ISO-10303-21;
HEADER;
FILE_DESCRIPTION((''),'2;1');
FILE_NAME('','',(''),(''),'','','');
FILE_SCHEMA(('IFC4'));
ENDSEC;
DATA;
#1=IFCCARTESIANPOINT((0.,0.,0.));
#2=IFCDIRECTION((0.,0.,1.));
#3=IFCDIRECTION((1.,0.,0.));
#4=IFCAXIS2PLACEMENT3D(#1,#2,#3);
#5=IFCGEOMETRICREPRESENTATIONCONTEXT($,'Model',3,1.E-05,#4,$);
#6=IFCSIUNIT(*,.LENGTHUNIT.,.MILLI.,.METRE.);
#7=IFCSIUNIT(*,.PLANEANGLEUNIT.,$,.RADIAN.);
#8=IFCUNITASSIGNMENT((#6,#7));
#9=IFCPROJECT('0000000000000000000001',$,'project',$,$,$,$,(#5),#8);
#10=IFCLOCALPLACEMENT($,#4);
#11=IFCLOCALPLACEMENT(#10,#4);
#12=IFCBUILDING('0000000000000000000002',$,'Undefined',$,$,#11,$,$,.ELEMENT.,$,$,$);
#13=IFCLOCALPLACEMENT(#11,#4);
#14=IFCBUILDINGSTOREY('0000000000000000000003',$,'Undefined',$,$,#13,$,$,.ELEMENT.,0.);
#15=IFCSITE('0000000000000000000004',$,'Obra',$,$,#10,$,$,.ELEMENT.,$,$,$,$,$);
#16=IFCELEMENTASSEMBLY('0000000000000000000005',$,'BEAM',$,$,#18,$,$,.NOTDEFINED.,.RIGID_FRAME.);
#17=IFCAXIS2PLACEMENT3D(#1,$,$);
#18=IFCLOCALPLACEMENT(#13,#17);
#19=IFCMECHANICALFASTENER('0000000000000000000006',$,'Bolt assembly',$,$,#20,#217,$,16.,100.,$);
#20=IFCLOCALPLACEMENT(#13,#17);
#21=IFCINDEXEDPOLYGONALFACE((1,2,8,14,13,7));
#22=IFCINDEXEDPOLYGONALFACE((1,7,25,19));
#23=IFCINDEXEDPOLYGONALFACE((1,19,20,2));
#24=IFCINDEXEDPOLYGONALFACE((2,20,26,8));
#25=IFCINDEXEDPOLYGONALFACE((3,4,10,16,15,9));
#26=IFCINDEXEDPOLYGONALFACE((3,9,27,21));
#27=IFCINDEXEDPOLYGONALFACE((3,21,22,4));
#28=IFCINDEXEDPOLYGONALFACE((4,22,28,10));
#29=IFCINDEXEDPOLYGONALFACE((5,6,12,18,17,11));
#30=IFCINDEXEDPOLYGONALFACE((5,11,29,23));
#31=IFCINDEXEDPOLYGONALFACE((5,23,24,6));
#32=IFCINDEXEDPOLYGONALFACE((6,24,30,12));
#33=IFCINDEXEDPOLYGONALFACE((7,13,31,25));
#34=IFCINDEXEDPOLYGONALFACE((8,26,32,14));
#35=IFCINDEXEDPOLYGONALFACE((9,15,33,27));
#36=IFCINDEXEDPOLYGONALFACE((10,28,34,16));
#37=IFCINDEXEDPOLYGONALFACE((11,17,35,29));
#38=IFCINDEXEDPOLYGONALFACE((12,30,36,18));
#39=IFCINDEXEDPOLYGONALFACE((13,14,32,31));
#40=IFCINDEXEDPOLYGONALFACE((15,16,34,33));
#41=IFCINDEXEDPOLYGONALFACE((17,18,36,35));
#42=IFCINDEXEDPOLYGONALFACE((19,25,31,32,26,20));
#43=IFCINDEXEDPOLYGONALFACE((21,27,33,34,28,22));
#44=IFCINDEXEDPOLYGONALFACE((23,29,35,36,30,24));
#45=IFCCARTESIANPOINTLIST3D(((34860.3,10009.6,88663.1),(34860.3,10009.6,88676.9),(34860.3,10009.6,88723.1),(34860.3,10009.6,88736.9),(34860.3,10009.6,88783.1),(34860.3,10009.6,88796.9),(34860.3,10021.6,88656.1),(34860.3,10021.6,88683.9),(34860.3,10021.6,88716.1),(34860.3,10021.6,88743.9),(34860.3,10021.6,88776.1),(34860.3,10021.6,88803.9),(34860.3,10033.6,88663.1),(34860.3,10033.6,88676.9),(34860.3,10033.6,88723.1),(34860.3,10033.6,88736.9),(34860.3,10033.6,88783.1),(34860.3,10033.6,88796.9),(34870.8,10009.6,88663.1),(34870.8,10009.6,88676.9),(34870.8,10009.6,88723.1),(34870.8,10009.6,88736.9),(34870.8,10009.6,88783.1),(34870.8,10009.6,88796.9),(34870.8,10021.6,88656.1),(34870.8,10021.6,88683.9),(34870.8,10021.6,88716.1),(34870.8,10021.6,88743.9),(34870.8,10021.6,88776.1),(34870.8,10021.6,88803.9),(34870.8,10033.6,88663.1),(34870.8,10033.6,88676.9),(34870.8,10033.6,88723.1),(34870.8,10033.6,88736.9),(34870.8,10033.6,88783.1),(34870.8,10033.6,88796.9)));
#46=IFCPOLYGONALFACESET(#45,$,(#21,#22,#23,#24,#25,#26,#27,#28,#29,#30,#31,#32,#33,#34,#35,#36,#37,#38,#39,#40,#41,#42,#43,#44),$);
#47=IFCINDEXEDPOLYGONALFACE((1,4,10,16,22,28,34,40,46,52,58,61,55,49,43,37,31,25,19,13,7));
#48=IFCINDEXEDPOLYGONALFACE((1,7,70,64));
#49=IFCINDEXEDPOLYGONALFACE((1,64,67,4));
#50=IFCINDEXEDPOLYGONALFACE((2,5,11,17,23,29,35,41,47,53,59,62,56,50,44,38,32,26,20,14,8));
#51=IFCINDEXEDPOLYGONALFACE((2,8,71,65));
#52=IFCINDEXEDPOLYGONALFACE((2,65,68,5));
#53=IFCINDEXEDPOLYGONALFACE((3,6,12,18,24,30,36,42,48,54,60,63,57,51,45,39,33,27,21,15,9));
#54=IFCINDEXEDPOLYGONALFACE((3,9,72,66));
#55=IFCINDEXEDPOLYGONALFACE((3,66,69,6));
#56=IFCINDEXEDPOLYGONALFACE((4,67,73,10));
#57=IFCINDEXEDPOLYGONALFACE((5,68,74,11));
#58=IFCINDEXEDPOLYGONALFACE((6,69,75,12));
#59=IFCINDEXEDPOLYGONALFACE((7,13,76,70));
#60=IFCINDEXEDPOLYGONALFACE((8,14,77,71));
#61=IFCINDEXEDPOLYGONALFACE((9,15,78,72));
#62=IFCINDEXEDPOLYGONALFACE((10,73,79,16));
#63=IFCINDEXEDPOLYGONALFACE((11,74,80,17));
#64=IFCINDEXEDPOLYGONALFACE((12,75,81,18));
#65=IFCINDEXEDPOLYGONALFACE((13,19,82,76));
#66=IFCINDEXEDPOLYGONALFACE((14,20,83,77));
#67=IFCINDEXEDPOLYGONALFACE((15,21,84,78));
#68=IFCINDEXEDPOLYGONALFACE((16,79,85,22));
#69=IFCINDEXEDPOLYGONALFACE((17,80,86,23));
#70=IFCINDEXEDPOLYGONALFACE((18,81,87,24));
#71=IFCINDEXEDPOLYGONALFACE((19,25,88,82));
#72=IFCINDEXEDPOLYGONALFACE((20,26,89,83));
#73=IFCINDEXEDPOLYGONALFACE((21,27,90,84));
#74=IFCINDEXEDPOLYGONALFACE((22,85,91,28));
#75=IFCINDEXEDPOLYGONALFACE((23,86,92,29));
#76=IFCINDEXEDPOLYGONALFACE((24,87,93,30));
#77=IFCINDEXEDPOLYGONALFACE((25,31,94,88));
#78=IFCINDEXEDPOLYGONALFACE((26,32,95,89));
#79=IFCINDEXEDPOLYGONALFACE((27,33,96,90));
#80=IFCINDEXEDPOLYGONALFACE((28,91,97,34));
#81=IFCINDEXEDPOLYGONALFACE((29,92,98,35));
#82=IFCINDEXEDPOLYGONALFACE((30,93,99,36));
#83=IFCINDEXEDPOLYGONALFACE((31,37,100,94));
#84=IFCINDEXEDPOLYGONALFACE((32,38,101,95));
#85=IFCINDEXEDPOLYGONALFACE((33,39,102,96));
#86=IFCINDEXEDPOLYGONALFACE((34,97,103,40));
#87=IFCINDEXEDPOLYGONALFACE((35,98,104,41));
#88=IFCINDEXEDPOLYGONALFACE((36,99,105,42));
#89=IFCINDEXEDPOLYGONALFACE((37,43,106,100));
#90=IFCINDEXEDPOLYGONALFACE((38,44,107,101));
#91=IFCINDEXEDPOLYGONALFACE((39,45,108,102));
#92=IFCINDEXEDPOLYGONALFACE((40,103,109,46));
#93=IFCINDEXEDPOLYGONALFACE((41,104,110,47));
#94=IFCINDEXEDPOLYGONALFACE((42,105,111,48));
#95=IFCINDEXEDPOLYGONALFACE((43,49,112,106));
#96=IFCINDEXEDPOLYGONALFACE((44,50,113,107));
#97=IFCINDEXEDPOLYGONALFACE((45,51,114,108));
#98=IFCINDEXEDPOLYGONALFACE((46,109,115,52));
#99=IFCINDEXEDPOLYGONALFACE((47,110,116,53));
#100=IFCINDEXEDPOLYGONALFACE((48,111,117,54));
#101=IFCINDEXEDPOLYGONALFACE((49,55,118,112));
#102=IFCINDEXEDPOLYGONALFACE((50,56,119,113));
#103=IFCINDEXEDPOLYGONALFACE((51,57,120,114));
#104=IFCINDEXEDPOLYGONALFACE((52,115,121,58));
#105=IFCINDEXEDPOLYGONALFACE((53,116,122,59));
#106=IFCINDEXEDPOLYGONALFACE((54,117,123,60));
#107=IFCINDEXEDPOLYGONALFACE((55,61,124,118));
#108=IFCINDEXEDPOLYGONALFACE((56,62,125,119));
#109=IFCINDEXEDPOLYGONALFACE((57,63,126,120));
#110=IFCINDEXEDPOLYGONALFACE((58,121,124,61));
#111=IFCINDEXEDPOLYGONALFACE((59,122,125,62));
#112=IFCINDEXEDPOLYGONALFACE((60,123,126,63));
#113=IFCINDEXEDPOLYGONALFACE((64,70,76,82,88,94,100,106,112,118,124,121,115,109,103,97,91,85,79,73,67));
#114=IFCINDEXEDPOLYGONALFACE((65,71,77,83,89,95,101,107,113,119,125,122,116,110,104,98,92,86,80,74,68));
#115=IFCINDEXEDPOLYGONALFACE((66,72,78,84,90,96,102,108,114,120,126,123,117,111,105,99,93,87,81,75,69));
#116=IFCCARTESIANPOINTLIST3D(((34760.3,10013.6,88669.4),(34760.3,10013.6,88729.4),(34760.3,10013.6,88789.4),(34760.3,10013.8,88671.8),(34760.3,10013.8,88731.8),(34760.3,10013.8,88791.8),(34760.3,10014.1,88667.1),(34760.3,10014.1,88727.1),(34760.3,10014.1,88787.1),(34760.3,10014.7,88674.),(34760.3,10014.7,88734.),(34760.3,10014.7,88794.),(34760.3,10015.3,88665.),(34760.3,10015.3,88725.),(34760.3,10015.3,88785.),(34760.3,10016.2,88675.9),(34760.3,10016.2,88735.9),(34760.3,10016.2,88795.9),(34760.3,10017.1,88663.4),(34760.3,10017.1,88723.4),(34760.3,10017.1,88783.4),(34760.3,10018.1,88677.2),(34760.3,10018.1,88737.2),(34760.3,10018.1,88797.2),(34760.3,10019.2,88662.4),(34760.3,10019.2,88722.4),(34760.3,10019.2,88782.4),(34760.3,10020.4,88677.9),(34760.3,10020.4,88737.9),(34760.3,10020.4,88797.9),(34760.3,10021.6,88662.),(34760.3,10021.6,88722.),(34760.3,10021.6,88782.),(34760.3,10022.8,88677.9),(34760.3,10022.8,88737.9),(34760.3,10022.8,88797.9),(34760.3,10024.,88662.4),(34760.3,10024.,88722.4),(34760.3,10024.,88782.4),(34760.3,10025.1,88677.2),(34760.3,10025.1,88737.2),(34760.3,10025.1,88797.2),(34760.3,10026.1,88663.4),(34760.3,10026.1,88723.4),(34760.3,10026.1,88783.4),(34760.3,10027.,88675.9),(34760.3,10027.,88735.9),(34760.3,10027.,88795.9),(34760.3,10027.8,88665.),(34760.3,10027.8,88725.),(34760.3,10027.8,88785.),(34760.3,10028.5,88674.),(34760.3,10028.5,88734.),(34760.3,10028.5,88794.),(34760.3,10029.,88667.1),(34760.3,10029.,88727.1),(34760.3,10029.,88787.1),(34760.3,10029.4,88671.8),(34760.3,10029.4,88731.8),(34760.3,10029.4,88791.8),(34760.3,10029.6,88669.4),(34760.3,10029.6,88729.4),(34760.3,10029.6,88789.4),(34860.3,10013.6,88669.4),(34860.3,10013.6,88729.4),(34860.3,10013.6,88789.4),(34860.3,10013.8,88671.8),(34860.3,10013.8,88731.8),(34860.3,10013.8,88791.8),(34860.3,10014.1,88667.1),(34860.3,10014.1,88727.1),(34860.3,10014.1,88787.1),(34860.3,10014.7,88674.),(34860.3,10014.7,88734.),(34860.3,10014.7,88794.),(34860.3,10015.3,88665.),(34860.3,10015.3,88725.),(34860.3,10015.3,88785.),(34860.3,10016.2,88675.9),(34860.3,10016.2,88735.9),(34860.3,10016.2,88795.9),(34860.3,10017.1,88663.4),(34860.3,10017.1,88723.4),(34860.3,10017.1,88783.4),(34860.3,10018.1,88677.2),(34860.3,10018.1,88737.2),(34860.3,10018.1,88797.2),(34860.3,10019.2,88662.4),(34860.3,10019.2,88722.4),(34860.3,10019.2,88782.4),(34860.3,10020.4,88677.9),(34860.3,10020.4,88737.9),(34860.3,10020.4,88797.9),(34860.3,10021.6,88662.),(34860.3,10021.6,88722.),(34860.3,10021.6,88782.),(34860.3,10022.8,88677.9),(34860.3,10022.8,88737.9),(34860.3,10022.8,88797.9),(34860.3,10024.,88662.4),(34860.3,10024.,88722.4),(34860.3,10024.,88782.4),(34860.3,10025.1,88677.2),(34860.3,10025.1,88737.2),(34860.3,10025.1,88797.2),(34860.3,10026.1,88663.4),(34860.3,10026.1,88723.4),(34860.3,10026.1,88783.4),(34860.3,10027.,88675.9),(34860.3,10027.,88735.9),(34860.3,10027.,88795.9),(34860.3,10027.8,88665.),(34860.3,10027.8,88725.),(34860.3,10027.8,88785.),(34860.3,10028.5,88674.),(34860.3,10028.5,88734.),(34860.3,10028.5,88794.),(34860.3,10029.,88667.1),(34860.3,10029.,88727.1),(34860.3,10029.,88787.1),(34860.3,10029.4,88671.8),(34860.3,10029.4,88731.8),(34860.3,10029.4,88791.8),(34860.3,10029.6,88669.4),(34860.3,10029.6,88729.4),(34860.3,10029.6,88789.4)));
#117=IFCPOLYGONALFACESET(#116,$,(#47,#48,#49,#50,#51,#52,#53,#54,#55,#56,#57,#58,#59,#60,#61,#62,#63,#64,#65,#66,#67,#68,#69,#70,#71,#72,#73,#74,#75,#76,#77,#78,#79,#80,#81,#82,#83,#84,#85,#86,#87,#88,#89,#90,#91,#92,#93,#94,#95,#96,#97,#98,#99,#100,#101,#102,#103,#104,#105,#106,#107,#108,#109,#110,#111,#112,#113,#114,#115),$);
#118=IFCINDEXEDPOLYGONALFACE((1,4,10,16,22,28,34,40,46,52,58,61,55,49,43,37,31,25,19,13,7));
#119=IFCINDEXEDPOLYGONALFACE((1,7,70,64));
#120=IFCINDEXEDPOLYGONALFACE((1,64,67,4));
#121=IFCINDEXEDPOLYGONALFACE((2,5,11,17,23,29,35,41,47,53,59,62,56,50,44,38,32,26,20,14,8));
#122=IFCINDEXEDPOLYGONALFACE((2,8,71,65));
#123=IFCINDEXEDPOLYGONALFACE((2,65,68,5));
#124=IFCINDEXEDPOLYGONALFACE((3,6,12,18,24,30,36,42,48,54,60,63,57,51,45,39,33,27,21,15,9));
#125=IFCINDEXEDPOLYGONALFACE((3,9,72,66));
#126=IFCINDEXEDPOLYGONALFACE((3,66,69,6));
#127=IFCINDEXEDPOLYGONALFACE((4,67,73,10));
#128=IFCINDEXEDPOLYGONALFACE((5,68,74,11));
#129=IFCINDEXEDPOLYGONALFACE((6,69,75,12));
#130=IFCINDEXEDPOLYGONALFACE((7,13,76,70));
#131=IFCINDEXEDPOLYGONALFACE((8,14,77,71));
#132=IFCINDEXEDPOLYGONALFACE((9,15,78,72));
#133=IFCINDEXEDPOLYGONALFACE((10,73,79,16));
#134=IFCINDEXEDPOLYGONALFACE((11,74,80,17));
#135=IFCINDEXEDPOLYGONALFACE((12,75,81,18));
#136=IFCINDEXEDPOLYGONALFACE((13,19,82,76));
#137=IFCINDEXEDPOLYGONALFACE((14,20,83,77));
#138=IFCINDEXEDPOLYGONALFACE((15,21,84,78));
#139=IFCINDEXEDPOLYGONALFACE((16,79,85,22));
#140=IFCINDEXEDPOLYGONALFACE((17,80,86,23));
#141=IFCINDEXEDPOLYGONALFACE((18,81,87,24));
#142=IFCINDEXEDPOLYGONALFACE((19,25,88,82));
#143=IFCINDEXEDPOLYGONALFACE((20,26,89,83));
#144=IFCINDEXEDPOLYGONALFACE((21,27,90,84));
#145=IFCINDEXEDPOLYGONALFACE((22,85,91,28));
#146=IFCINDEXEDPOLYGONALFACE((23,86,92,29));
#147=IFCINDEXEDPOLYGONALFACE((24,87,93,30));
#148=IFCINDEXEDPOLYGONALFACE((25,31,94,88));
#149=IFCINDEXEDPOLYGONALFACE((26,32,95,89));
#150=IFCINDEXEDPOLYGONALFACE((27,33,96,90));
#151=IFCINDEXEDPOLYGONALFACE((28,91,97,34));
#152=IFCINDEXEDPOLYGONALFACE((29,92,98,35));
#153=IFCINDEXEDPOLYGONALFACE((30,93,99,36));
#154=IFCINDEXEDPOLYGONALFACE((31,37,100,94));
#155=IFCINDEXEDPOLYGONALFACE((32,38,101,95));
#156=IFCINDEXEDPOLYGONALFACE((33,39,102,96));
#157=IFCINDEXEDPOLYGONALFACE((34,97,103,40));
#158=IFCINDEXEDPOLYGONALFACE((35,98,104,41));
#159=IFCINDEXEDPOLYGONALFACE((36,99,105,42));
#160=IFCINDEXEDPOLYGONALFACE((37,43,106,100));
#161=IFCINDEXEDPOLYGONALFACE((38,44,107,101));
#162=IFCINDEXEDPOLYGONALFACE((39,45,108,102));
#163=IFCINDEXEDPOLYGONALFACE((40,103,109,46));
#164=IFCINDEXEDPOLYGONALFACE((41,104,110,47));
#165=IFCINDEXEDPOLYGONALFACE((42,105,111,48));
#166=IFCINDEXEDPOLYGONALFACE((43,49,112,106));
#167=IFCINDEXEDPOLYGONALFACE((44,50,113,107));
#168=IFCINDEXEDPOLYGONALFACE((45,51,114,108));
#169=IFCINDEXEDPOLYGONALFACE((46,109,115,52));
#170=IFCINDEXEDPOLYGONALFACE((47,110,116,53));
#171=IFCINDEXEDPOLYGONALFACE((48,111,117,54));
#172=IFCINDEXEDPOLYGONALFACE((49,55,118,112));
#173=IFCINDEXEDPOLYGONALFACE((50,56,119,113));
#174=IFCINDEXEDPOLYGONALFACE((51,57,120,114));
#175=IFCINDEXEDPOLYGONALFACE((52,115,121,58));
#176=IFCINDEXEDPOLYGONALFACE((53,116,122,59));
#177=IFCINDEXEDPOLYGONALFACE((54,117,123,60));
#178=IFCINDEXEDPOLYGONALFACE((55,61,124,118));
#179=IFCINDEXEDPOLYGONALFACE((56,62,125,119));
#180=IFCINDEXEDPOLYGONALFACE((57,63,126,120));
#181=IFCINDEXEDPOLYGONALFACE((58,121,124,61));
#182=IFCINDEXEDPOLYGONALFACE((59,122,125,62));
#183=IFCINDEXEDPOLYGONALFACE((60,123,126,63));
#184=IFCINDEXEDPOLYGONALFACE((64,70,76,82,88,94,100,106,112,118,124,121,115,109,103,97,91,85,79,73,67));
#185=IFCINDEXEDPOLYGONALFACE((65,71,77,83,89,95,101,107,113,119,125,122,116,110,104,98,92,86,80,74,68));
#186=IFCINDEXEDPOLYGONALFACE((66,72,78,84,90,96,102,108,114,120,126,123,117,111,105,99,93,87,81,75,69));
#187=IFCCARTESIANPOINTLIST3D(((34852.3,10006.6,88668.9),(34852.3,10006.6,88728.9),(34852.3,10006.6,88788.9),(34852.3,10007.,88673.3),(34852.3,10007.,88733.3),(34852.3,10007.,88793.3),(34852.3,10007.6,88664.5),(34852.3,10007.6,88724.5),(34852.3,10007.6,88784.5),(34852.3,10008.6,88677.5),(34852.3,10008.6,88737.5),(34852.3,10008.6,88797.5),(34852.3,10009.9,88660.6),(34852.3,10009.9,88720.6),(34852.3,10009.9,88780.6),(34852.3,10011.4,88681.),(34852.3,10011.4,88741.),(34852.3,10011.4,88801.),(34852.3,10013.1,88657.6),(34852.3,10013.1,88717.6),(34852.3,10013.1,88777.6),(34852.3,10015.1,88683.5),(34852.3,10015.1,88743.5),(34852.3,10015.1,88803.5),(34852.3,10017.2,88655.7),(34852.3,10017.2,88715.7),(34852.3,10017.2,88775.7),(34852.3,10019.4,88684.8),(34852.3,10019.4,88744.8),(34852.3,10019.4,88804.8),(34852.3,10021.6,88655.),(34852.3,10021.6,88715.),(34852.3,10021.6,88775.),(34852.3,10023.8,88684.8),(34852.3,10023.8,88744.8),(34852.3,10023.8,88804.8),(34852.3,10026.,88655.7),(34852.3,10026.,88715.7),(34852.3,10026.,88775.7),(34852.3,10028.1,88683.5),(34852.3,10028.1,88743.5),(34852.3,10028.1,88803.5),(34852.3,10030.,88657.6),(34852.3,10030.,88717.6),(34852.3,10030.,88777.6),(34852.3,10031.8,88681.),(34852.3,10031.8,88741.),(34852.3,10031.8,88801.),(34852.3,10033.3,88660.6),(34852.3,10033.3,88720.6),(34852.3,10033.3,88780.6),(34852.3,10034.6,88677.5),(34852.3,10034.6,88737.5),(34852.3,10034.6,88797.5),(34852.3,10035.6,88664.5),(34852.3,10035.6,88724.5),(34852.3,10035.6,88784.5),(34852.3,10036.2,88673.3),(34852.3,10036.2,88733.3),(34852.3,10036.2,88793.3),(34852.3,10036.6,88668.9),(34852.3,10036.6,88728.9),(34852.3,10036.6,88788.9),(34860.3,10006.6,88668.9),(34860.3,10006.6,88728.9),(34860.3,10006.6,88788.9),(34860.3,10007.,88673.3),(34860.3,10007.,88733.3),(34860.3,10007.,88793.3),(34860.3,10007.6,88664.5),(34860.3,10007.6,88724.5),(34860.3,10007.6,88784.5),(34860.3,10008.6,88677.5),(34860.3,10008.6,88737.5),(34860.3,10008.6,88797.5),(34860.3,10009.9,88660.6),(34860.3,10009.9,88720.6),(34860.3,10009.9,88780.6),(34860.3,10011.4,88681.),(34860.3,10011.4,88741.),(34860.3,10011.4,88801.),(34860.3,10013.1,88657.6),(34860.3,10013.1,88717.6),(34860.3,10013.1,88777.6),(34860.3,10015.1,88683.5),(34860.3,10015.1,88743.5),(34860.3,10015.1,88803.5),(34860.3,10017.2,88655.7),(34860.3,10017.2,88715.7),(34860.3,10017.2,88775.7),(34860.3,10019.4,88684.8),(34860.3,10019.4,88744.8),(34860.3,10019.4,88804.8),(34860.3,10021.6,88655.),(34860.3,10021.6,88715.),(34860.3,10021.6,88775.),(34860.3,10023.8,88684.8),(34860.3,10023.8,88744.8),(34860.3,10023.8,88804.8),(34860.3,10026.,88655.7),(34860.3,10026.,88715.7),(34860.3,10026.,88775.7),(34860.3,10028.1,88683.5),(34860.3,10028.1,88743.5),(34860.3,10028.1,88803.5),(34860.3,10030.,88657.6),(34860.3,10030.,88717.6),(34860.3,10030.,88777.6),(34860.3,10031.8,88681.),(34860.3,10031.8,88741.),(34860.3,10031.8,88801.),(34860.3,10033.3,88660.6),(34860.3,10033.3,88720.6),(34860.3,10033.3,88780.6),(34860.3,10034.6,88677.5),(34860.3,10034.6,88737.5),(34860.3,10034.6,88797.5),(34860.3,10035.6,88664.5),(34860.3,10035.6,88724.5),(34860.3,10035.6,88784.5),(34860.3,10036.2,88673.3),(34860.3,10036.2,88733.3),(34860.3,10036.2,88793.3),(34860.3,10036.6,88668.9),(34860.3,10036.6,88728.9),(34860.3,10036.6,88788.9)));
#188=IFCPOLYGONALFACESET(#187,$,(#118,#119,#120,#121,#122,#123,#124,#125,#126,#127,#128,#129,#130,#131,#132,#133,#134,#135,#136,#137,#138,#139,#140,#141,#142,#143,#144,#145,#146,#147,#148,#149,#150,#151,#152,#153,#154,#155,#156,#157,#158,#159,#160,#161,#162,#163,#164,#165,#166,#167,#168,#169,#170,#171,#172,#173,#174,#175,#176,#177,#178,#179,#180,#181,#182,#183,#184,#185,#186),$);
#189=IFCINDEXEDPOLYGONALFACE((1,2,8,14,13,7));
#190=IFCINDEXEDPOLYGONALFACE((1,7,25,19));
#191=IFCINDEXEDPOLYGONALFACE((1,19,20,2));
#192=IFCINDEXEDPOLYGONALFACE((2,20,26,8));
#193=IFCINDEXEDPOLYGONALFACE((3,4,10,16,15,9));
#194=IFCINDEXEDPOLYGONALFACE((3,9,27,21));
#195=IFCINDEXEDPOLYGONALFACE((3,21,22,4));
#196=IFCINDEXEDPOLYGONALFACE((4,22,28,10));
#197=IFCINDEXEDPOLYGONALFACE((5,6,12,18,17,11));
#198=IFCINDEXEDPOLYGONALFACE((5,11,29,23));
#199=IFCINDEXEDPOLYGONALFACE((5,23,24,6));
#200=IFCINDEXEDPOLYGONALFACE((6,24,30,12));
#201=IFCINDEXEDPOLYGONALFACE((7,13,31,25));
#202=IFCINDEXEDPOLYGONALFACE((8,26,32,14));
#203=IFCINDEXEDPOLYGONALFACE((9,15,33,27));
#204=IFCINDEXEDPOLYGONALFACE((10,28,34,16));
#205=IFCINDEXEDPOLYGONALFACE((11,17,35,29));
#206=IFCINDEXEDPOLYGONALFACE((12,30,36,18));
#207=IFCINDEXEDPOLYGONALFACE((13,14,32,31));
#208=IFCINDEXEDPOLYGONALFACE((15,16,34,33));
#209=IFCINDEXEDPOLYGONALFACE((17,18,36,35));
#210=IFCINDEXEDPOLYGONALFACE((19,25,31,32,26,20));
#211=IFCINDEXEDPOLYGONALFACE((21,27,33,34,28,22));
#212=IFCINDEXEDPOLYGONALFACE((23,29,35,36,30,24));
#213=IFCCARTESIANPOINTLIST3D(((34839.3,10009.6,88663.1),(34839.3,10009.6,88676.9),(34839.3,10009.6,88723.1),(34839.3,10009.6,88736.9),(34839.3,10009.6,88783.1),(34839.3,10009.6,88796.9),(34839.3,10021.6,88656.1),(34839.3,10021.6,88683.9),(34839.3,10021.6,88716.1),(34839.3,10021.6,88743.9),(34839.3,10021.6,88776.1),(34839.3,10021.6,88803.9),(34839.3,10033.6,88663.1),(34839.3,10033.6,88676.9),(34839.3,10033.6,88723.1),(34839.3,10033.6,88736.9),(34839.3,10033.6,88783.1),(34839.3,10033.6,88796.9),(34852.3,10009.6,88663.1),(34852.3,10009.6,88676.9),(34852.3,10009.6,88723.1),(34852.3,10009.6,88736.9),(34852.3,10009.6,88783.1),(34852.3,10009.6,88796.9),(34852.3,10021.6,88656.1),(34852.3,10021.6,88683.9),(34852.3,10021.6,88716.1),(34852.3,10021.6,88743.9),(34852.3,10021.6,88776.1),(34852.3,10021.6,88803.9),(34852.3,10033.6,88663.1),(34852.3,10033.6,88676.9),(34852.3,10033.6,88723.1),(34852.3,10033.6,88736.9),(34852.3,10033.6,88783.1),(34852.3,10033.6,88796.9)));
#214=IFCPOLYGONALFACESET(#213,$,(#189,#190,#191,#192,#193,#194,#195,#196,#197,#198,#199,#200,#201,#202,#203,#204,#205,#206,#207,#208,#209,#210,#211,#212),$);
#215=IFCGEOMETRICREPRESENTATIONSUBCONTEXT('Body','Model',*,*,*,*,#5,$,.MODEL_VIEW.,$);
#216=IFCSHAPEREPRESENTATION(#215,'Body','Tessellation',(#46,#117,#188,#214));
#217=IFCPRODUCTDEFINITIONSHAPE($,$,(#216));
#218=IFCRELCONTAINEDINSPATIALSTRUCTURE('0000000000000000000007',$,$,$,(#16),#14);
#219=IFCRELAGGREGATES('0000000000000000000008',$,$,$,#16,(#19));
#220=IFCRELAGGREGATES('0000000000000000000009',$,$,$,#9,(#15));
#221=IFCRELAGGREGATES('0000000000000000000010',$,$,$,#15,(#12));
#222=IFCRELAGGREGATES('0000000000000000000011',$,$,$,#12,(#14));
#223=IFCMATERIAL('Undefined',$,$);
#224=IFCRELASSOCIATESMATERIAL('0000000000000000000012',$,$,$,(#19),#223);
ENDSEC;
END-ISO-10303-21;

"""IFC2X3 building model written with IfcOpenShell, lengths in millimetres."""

from ifc_helpers import new_model, si_unit, frame, origin_with_axes, origin_2d_with_axis, place, context, subcontext, project, spatial, polyline, circle, outline, extrude, source, transform, mapped, material, element, aggregate, save


model = new_model("IFC2X3")

# Units and contexts
model_context = context("Model", 3, precision=1e-05, world=origin_with_axes())
body_context = subcontext(model_context, "Body", "Model", "MODEL_VIEW")
ifc_project = project(units=[si_unit("LENGTHUNIT", "METRE", prefix="MILLI"), si_unit("PLANEANGLEUNIT", "RADIAN")], contexts=[model_context])

# Site, building, storey
site_placement = place(None, origin_with_axes())
site = spatial("IfcSite", under=ifc_project, at=site_placement, Name="Obra", CompositionType="ELEMENT")
building_placement = place(site_placement, origin_with_axes())
building = spatial("IfcBuilding", under=site, at=building_placement, Name="Undefined", CompositionType="ELEMENT")
storey_placement = place(building_placement, origin_with_axes())
storey = spatial("IfcBuildingStorey", under=building, at=storey_placement, Name="Undefined", CompositionType="ELEMENT", Elevation=0.0)

# Shared definitions
ifc_material_1 = material(Name="Undefined")

# Element assembly, mechanical fastener
assembly_1_placement = place(storey_placement, origin_with_axes())
assembly_1 = element("IfcElementAssembly", 1, at=assembly_1_placement, inside=storey, Name="BEAM", AssemblyPlace="NOTDEFINED", PredefinedType="RIGID_FRAME")
shared_shape_1 = source(origin_with_axes(), body_context, "Body", "SweptSolid", [
    extrude(outline(polyline([(13.9, 0.0), (6.9, 12.0), (-6.9, 12.0), (-13.9, 0.0), (-6.9, -12.0), (6.9, -12.0), (13.9, 0.0)])), frame((0.0, -10.6, 0.0), z_axis=(0.0, 1.0, 0.0), x_axis=(1.0, 0.0, 0.0)), (0.0, 0.0, 1.0), 10.6),
    extrude(circle(Radius=8.0, at=origin_2d_with_axis()), frame((0.0, 0.0, 0.0), z_axis=(0.0, 1.0, 0.0), x_axis=(1.0, 0.0, 0.0)), (0.0, 0.0, 1.0), 100.0),
    extrude(circle(Radius=15.0, at=origin_2d_with_axis()), frame((0.0, 0.0, 0.0), z_axis=(0.0, 1.0, 0.0), x_axis=(1.0, 0.0, 0.0)), (0.0, 0.0, 1.0), 8.0),
    extrude(outline(polyline([(13.9, 0.0), (6.9, 12.0), (-6.9, 12.0), (-13.9, 0.0), (-6.9, -12.0), (6.9, -12.0), (13.9, 0.0)])), frame((0.0, 8.0, 0.0), z_axis=(0.0, 1.0, 0.0), x_axis=(1.0, 0.0, 0.0)), (0.0, 0.0, 1.0), 13.0),
])
mechanical_fastener_1_placement = place(assembly_1_placement, frame((34860.3, 9971.6, 88850.0), z_axis=(0.0, 1.0, 0.0), x_axis=(0.0, 0.0, -1.0)))
mechanical_fastener_1 = element("IfcMechanicalFastener", 2, at=mechanical_fastener_1_placement, material=ifc_material_1, Name="Bolt assembly", NominalDiameter=16.0, NominalLength=100.0, context=body_context, shape_type="MappedRepresentation", body=[
    mapped(shared_shape_1, transform((60.0, 0.0, 50.0))),
    mapped(shared_shape_1, transform((120.0, 0.0, 50.0))),
    mapped(shared_shape_1, transform((180.0, 0.0, 50.0))),
])
aggregate(assembly_1, [mechanical_fastener_1])

save(model, "model.ifc")
